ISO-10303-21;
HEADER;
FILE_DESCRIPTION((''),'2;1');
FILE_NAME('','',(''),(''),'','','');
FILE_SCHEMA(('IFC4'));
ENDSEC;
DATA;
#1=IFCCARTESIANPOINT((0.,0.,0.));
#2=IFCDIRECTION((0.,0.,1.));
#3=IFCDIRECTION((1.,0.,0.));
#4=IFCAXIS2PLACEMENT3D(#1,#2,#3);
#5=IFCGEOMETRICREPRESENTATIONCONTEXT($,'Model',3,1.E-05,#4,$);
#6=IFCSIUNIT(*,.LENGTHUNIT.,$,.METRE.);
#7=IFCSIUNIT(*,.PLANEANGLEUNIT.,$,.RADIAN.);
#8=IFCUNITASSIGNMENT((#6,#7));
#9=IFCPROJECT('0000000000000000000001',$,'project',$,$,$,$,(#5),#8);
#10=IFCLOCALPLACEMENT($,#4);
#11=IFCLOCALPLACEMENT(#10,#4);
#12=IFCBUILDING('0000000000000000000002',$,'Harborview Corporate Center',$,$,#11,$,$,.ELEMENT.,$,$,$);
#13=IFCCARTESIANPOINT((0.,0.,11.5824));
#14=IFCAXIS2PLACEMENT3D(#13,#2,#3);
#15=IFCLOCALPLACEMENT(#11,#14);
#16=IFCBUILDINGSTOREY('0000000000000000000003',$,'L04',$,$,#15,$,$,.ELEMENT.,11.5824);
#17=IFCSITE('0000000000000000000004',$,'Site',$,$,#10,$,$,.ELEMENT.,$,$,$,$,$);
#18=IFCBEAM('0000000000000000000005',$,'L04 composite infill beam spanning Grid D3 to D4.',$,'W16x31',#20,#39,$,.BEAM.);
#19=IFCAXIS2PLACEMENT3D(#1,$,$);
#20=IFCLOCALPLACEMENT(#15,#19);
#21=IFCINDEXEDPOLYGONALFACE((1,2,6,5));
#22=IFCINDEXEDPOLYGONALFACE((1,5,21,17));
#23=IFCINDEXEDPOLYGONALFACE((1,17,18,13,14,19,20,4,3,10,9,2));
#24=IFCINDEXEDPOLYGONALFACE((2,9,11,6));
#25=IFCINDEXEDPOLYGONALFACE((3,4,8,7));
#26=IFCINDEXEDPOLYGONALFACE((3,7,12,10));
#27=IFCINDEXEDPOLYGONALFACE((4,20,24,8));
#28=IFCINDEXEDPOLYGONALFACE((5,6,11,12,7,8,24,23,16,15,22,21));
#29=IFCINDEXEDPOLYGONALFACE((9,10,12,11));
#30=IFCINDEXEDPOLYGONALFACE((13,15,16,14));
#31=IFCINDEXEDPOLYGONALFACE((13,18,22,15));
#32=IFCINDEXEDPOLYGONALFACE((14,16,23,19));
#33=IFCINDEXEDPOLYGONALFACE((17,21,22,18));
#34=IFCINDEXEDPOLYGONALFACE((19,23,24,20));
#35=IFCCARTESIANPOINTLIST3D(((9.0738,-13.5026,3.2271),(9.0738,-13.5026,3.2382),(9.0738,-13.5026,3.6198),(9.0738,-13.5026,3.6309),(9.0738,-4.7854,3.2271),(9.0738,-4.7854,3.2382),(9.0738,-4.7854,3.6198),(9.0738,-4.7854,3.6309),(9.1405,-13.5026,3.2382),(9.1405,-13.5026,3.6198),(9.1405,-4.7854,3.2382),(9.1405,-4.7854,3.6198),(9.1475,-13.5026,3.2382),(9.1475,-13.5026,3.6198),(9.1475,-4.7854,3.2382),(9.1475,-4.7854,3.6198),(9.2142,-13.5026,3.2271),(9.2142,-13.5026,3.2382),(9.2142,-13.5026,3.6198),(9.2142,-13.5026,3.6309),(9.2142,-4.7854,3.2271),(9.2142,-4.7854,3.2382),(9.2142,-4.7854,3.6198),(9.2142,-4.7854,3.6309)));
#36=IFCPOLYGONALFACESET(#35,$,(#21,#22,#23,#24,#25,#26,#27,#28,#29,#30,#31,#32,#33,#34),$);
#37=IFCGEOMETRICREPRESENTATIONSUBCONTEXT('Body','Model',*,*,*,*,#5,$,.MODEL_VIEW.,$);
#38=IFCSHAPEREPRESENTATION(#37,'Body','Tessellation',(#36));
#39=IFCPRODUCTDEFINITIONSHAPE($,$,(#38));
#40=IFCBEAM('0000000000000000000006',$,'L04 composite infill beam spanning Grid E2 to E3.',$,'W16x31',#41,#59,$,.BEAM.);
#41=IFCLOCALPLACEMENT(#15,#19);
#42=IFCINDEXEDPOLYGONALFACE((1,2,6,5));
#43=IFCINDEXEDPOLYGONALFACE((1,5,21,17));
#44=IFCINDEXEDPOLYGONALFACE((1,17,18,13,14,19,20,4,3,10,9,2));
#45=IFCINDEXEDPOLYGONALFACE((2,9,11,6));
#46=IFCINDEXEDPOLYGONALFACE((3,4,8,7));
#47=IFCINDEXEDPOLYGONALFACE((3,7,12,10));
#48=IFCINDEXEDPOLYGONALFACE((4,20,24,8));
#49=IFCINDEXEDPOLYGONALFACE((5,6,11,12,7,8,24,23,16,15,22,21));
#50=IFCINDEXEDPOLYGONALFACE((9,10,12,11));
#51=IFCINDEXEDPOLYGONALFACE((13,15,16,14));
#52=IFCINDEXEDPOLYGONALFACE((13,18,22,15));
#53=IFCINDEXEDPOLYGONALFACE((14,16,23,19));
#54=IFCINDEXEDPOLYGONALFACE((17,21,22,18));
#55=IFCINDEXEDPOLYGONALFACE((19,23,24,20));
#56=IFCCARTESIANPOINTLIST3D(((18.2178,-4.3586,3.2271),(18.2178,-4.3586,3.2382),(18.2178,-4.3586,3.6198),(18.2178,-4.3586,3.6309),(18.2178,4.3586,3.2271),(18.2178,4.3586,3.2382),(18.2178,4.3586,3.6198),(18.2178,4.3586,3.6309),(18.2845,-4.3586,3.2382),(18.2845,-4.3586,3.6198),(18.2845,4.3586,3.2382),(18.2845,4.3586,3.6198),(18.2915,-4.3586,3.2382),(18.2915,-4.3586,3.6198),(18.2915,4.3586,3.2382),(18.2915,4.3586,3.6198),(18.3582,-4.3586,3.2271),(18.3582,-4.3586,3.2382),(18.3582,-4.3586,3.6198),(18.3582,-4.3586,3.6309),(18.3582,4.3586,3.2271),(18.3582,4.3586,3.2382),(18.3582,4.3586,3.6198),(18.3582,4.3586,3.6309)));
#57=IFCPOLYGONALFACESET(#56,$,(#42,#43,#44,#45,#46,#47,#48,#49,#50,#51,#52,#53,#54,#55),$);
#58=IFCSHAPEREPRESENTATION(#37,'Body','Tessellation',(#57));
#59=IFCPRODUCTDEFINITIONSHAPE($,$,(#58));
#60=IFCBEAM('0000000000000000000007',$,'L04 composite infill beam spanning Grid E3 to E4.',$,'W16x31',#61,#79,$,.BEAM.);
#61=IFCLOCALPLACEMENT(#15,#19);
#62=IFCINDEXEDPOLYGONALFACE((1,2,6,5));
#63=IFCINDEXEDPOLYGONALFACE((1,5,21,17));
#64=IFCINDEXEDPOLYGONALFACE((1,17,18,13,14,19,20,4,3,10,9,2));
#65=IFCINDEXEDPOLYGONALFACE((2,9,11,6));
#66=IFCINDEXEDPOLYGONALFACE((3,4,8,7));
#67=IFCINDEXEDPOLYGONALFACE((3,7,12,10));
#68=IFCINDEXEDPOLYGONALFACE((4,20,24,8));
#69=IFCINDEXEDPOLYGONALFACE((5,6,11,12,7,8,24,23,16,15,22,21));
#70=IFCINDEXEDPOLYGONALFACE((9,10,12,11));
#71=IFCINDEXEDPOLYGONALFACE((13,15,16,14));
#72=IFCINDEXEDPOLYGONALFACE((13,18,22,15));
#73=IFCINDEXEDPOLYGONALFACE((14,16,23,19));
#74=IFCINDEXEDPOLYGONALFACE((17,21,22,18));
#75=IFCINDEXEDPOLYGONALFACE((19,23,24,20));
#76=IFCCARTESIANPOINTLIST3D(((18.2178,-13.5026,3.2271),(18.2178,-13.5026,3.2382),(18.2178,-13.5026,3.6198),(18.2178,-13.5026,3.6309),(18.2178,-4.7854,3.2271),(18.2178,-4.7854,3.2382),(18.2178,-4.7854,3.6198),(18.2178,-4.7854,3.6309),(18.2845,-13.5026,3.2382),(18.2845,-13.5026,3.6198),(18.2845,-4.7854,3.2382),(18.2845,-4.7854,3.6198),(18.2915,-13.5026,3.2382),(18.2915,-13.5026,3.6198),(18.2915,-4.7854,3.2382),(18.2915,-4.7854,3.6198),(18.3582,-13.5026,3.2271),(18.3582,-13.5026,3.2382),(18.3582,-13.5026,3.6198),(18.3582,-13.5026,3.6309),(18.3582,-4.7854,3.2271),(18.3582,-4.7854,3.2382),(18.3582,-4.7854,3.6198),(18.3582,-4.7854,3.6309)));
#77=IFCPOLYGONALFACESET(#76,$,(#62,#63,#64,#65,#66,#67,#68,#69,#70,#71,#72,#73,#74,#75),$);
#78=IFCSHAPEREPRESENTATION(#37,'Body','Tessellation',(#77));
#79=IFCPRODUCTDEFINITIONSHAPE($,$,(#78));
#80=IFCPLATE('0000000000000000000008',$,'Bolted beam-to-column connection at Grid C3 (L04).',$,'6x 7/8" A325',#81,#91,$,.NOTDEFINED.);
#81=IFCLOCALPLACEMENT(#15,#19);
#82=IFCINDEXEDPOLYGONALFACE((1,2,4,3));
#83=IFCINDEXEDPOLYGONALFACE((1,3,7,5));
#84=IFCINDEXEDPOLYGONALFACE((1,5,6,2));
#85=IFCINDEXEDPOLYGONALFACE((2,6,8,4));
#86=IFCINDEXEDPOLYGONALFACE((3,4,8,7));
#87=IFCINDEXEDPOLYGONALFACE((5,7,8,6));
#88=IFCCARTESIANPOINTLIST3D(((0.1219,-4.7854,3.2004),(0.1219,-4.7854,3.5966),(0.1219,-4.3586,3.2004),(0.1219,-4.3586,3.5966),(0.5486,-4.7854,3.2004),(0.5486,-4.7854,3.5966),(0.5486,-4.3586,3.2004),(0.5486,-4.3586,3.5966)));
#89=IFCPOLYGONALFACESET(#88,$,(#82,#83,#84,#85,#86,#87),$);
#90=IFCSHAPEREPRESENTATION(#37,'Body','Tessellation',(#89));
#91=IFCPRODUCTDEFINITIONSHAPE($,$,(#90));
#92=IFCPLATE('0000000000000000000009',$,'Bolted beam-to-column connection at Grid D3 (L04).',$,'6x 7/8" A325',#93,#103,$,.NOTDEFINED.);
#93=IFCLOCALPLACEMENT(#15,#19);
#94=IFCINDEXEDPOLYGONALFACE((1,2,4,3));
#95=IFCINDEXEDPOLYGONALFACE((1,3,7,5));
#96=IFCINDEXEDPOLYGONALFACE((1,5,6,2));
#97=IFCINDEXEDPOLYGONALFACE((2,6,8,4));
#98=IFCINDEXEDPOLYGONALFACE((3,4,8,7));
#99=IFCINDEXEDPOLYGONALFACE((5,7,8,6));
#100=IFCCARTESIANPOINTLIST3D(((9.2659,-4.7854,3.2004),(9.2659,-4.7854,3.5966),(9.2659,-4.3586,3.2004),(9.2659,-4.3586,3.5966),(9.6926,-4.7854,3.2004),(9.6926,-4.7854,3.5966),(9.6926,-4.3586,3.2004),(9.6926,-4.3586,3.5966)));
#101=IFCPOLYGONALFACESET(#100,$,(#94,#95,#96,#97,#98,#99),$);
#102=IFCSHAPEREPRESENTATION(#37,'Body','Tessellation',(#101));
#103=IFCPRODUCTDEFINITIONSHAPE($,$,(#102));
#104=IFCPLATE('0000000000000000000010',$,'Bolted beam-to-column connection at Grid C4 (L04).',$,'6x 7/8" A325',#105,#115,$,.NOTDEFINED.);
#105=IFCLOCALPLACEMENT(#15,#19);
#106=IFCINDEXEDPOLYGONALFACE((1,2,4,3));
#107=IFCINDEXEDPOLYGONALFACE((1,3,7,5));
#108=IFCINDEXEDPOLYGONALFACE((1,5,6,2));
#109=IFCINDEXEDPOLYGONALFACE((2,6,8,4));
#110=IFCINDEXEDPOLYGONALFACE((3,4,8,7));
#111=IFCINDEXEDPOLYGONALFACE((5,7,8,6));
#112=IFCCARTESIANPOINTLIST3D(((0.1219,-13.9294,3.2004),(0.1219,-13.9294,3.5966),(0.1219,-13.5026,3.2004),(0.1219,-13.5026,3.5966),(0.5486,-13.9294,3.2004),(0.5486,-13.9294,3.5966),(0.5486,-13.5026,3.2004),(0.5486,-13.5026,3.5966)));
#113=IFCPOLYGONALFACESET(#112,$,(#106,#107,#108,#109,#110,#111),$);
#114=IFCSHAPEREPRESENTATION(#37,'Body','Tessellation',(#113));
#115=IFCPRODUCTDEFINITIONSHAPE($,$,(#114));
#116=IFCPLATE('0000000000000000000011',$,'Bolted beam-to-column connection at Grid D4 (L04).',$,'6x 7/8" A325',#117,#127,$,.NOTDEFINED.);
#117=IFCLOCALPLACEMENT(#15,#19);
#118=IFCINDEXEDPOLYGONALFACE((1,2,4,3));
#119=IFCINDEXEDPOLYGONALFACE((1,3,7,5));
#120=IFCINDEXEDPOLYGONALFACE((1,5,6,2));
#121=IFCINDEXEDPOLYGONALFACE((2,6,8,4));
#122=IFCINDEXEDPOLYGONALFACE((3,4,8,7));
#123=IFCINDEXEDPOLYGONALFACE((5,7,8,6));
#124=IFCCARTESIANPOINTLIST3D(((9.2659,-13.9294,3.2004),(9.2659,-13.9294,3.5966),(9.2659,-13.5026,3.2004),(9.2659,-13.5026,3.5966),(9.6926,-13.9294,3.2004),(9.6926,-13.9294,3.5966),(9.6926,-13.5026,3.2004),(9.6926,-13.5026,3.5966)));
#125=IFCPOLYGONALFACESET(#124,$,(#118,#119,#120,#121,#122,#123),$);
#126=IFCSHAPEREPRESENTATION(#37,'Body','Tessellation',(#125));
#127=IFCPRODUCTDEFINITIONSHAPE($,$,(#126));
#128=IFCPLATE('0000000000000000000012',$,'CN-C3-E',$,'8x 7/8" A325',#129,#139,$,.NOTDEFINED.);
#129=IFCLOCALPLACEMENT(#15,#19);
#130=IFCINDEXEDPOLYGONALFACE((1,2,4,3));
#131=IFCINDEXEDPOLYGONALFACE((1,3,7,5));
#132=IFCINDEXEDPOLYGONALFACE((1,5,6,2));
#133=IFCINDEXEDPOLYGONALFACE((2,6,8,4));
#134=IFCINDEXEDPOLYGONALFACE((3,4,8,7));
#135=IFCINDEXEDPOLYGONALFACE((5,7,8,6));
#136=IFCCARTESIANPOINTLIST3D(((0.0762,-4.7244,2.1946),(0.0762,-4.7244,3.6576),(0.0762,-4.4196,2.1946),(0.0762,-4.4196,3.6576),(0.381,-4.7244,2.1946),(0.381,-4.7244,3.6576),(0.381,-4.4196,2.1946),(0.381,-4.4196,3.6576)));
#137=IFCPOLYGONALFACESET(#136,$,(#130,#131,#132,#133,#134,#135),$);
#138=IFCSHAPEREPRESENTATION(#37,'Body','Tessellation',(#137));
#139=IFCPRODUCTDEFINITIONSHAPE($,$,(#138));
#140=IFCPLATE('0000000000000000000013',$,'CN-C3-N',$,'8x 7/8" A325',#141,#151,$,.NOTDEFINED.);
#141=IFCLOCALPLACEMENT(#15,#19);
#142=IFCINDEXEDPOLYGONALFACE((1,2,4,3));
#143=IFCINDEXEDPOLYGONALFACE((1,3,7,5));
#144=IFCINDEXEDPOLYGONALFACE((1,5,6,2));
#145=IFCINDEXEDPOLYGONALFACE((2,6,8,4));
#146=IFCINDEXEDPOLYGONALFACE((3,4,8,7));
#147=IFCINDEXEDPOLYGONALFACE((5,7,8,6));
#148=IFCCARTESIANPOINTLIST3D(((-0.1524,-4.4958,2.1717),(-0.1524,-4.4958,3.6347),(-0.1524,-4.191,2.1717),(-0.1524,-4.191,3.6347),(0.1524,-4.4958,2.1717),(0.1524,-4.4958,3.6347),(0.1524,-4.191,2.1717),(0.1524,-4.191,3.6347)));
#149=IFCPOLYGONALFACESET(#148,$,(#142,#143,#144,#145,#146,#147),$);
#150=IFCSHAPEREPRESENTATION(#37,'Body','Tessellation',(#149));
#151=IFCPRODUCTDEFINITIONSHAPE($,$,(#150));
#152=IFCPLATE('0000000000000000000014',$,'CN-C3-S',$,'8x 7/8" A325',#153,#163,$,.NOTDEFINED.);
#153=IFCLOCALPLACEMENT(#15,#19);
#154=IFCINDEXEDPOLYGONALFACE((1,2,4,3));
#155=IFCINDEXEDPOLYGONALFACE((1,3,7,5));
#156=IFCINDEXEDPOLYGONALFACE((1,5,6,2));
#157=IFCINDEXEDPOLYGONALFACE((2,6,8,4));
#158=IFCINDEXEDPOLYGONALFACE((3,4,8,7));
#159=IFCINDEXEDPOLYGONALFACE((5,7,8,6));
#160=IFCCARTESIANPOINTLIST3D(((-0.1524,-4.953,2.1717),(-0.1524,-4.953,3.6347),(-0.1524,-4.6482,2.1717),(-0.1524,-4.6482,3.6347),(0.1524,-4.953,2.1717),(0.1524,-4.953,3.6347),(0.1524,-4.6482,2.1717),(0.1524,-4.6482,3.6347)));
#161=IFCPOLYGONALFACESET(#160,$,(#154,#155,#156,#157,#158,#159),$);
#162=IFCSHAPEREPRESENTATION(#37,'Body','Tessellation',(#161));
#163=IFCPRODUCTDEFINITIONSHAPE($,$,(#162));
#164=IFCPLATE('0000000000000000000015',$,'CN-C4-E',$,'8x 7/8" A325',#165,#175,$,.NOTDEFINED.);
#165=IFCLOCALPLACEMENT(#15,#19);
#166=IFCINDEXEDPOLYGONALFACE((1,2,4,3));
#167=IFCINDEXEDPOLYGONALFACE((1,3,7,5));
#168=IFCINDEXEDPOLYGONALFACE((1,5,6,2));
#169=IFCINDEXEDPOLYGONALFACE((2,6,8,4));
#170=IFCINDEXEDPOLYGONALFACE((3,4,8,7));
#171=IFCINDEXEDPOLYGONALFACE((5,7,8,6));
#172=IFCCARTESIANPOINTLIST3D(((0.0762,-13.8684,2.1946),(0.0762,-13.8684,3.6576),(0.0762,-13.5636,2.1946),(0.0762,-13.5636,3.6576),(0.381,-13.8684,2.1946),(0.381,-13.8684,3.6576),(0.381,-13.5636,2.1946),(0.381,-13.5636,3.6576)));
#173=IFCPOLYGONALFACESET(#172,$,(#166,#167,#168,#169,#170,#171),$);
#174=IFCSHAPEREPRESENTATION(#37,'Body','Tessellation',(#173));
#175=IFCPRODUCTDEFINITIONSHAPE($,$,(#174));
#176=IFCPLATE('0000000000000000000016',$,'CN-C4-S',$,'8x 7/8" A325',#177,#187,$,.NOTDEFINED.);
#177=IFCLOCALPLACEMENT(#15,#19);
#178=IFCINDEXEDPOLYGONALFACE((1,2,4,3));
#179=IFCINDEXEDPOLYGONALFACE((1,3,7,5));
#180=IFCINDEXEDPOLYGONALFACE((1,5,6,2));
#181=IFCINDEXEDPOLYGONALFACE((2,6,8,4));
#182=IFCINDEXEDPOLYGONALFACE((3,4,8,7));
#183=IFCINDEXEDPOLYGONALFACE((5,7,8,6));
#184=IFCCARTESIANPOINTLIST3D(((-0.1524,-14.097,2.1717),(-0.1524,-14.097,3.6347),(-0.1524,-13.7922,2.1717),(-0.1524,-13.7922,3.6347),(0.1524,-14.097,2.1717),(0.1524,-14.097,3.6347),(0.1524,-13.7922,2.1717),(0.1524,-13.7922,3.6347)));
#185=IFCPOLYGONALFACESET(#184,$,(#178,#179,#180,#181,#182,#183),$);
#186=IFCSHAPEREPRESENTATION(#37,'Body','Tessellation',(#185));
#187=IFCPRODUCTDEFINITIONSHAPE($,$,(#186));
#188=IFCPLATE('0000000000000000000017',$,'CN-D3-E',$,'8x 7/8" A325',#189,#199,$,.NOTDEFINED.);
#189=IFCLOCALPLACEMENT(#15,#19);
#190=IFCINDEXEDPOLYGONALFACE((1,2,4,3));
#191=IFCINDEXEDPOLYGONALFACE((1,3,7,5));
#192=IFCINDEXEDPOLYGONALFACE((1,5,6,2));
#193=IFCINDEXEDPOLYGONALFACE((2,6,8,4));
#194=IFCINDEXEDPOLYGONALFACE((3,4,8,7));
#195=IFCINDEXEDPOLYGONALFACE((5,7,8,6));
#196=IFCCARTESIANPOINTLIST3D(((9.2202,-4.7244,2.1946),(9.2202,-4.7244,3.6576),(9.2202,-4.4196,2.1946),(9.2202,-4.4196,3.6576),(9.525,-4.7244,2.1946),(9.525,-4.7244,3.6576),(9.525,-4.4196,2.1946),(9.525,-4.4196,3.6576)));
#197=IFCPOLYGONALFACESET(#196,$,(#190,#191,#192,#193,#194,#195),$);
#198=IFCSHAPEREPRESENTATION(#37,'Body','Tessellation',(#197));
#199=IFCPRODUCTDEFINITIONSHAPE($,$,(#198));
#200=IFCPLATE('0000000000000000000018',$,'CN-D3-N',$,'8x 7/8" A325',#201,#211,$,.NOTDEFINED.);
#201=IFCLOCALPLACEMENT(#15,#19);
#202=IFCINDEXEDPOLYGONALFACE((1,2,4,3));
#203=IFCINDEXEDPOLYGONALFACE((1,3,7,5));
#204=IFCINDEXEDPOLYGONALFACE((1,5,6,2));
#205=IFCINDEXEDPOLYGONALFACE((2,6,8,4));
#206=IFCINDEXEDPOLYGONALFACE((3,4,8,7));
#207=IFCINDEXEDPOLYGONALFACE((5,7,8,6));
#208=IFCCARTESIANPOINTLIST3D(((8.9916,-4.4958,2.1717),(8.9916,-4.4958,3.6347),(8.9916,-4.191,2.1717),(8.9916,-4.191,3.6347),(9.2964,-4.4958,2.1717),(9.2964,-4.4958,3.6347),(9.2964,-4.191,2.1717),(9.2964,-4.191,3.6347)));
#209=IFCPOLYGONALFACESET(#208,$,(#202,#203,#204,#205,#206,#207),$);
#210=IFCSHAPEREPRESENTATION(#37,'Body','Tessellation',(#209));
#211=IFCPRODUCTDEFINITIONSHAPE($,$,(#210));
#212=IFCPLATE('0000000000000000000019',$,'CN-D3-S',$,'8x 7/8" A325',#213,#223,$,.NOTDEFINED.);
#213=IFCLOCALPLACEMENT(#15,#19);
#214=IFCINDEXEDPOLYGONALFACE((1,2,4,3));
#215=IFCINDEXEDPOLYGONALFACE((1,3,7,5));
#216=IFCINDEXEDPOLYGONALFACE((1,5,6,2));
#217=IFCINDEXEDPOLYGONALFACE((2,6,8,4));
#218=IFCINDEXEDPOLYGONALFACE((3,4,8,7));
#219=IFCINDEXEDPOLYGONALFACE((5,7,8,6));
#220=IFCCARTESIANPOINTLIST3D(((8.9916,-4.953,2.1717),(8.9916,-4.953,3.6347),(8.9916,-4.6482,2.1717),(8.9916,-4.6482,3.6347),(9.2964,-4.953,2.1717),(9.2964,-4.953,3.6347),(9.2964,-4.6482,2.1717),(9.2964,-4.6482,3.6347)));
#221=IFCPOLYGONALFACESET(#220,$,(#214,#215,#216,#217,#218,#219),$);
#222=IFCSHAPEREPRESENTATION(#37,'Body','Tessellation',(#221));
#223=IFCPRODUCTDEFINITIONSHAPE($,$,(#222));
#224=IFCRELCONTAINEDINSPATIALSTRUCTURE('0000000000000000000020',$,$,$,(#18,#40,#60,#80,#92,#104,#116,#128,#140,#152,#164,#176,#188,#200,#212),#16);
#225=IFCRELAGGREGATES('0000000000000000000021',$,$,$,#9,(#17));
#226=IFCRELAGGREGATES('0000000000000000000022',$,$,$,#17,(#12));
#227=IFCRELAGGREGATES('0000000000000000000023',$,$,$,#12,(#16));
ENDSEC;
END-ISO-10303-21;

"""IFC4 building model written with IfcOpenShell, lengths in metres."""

from ifc_helpers import new_model, si_unit, frame, origin_with_axes, place, context, subcontext, project, spatial, rectangle, i_section, extrude, element, save


model = new_model("IFC4")

# Units and contexts
model_context = context("Model", 3, precision=1e-05, world=origin_with_axes())
body_context = subcontext(model_context, "Body", "Model", "MODEL_VIEW")
ifc_project = project(units=[si_unit("LENGTHUNIT", "METRE"), si_unit("PLANEANGLEUNIT", "RADIAN")], contexts=[model_context])

# Site, building, storey
site_placement = place(None, origin_with_axes())
site = spatial("IfcSite", under=ifc_project, at=site_placement, Name="Site", CompositionType="ELEMENT")
building_placement = place(site_placement, origin_with_axes())
building = spatial("IfcBuilding", under=site, at=building_placement, Name="Harborview Corporate Center", CompositionType="ELEMENT")
storey_placement = place(building_placement, frame((0.0, 0.0, 11.5824), z_axis=(0.0, 0.0, 1.0), x_axis=(1.0, 0.0, 0.0)))
storey = spatial("IfcBuildingStorey", under=building, at=storey_placement, Name="L04", CompositionType="ELEMENT", Elevation=11.5824)

# Beams
beam_1_placement = place(storey_placement, frame((9.144, -13.5026, 3.429), z_axis=(0.0, 1.0, 0.0), x_axis=(-1.0, 0.0, 0.0)))
element("IfcBeam", 1, at=beam_1_placement, inside=storey, Name="L04 composite infill beam spanning Grid D3 to D4.", ObjectType="W16x31", PredefinedType="BEAM", context=body_context, shape_type="SweptSolid", body=[
    extrude(i_section(OverallWidth=0.1405, OverallDepth=0.4039, WebThickness=0.007, FlangeThickness=0.0112), origin_with_axes(), (0.0, 0.0, 1.0), 8.7173),
])
beam_2_placement = place(storey_placement, frame((18.288, -4.3586, 3.429), z_axis=(0.0, 1.0, 0.0), x_axis=(-1.0, 0.0, 0.0)))
element("IfcBeam", 2, at=beam_2_placement, inside=storey, Name="L04 composite infill beam spanning Grid E2 to E3.", ObjectType="W16x31", PredefinedType="BEAM", context=body_context, shape_type="SweptSolid", body=[
    extrude(i_section(OverallWidth=0.1405, OverallDepth=0.4039, WebThickness=0.007, FlangeThickness=0.0112), origin_with_axes(), (0.0, 0.0, 1.0), 8.7173),
])
beam_3_placement = place(storey_placement, frame((18.288, -13.5026, 3.429), z_axis=(0.0, 1.0, 0.0), x_axis=(-1.0, 0.0, 0.0)))
element("IfcBeam", 3, at=beam_3_placement, inside=storey, Name="L04 composite infill beam spanning Grid E3 to E4.", ObjectType="W16x31", PredefinedType="BEAM", context=body_context, shape_type="SweptSolid", body=[
    extrude(i_section(OverallWidth=0.1405, OverallDepth=0.4039, WebThickness=0.007, FlangeThickness=0.0112), origin_with_axes(), (0.0, 0.0, 1.0), 8.7173),
])

# Plates
plate_1_placement = place(storey_placement, frame((0.3353, -4.572, 3.2004), z_axis=(0.0, 0.0, 1.0), x_axis=(1.0, 0.0, 0.0)))
element("IfcPlate", 4, at=plate_1_placement, inside=storey, Name="Bolted beam-to-column connection at Grid C3 (L04).", ObjectType="6x 7/8\" A325", PredefinedType="NOTDEFINED", context=body_context, shape_type="SweptSolid", body=[
    extrude(rectangle(XDim=0.4267, YDim=0.4267), origin_with_axes(), (0.0, 0.0, 1.0), 0.3962),
])
plate_2_placement = place(storey_placement, frame((9.4793, -4.572, 3.2004), z_axis=(0.0, 0.0, 1.0), x_axis=(1.0, 0.0, 0.0)))
element("IfcPlate", 5, at=plate_2_placement, inside=storey, Name="Bolted beam-to-column connection at Grid D3 (L04).", ObjectType="6x 7/8\" A325", PredefinedType="NOTDEFINED", context=body_context, shape_type="SweptSolid", body=[
    extrude(rectangle(XDim=0.4267, YDim=0.4267), origin_with_axes(), (0.0, 0.0, 1.0), 0.3962),
])
plate_3_placement = place(storey_placement, frame((0.3353, -13.716, 3.2004), z_axis=(0.0, 0.0, 1.0), x_axis=(1.0, 0.0, 0.0)))
element("IfcPlate", 6, at=plate_3_placement, inside=storey, Name="Bolted beam-to-column connection at Grid C4 (L04).", ObjectType="6x 7/8\" A325", PredefinedType="NOTDEFINED", context=body_context, shape_type="SweptSolid", body=[
    extrude(rectangle(XDim=0.4267, YDim=0.4267), origin_with_axes(), (0.0, 0.0, 1.0), 0.3962),
])
plate_4_placement = place(storey_placement, frame((9.4793, -13.716, 3.2004), z_axis=(0.0, 0.0, 1.0), x_axis=(1.0, 0.0, 0.0)))
element("IfcPlate", 7, at=plate_4_placement, inside=storey, Name="Bolted beam-to-column connection at Grid D4 (L04).", ObjectType="6x 7/8\" A325", PredefinedType="NOTDEFINED", context=body_context, shape_type="SweptSolid", body=[
    extrude(rectangle(XDim=0.4267, YDim=0.4267), origin_with_axes(), (0.0, 0.0, 1.0), 0.3962),
])
for number, where, z_axis, x_axis, name in (
    (8, (0.2286, -4.572, 2.1946), (0.0, 0.0, 1.0), (1.0, 0.0, 0.0), "CN-C3-E"),
    (9, (0.0, -4.3434, 2.1717), (0.0, 0.0, 1.0), (1.0, 0.0, 0.0), "CN-C3-N"),
    (10, (0.0, -4.8006, 2.1717), (0.0, 0.0, 1.0), (1.0, 0.0, 0.0), "CN-C3-S"),
    (11, (0.2286, -13.716, 2.1946), (0.0, 0.0, 1.0), (1.0, 0.0, 0.0), "CN-C4-E"),
    (12, (0.0, -13.9446, 2.1717), (0.0, 0.0, 1.0), (1.0, 0.0, 0.0), "CN-C4-S"),
):
    element("IfcPlate", number, at=place(storey_placement, frame(where, z_axis=z_axis, x_axis=x_axis)), inside=storey, Name=name, ObjectType="8x 7/8\" A325", PredefinedType="NOTDEFINED", context=body_context, shape_type="SweptSolid", body=[
        extrude(rectangle(XDim=0.3048, YDim=0.3048), origin_with_axes(), (0.0, 0.0, 1.0), 1.463),
    ])
for number, where, z_axis, x_axis, name in (
    (13, (9.3726, -4.572, 2.1946), (0.0, 0.0, 1.0), (1.0, 0.0, 0.0), "CN-D3-E"),
    (14, (9.144, -4.3434, 2.1717), (0.0, 0.0, 1.0), (1.0, 0.0, 0.0), "CN-D3-N"),
    (15, (9.144, -4.8006, 2.1717), (0.0, 0.0, 1.0), (1.0, 0.0, 0.0), "CN-D3-S"),
):
    element("IfcPlate", number, at=place(storey_placement, frame(where, z_axis=z_axis, x_axis=x_axis)), inside=storey, Name=name, ObjectType="8x 7/8\" A325", PredefinedType="NOTDEFINED", context=body_context, shape_type="SweptSolid", body=[
        extrude(rectangle(XDim=0.3048, YDim=0.3048), origin_with_axes(), (0.0, 0.0, 1.0), 1.463),
    ])

save(model, "model.ifc")
